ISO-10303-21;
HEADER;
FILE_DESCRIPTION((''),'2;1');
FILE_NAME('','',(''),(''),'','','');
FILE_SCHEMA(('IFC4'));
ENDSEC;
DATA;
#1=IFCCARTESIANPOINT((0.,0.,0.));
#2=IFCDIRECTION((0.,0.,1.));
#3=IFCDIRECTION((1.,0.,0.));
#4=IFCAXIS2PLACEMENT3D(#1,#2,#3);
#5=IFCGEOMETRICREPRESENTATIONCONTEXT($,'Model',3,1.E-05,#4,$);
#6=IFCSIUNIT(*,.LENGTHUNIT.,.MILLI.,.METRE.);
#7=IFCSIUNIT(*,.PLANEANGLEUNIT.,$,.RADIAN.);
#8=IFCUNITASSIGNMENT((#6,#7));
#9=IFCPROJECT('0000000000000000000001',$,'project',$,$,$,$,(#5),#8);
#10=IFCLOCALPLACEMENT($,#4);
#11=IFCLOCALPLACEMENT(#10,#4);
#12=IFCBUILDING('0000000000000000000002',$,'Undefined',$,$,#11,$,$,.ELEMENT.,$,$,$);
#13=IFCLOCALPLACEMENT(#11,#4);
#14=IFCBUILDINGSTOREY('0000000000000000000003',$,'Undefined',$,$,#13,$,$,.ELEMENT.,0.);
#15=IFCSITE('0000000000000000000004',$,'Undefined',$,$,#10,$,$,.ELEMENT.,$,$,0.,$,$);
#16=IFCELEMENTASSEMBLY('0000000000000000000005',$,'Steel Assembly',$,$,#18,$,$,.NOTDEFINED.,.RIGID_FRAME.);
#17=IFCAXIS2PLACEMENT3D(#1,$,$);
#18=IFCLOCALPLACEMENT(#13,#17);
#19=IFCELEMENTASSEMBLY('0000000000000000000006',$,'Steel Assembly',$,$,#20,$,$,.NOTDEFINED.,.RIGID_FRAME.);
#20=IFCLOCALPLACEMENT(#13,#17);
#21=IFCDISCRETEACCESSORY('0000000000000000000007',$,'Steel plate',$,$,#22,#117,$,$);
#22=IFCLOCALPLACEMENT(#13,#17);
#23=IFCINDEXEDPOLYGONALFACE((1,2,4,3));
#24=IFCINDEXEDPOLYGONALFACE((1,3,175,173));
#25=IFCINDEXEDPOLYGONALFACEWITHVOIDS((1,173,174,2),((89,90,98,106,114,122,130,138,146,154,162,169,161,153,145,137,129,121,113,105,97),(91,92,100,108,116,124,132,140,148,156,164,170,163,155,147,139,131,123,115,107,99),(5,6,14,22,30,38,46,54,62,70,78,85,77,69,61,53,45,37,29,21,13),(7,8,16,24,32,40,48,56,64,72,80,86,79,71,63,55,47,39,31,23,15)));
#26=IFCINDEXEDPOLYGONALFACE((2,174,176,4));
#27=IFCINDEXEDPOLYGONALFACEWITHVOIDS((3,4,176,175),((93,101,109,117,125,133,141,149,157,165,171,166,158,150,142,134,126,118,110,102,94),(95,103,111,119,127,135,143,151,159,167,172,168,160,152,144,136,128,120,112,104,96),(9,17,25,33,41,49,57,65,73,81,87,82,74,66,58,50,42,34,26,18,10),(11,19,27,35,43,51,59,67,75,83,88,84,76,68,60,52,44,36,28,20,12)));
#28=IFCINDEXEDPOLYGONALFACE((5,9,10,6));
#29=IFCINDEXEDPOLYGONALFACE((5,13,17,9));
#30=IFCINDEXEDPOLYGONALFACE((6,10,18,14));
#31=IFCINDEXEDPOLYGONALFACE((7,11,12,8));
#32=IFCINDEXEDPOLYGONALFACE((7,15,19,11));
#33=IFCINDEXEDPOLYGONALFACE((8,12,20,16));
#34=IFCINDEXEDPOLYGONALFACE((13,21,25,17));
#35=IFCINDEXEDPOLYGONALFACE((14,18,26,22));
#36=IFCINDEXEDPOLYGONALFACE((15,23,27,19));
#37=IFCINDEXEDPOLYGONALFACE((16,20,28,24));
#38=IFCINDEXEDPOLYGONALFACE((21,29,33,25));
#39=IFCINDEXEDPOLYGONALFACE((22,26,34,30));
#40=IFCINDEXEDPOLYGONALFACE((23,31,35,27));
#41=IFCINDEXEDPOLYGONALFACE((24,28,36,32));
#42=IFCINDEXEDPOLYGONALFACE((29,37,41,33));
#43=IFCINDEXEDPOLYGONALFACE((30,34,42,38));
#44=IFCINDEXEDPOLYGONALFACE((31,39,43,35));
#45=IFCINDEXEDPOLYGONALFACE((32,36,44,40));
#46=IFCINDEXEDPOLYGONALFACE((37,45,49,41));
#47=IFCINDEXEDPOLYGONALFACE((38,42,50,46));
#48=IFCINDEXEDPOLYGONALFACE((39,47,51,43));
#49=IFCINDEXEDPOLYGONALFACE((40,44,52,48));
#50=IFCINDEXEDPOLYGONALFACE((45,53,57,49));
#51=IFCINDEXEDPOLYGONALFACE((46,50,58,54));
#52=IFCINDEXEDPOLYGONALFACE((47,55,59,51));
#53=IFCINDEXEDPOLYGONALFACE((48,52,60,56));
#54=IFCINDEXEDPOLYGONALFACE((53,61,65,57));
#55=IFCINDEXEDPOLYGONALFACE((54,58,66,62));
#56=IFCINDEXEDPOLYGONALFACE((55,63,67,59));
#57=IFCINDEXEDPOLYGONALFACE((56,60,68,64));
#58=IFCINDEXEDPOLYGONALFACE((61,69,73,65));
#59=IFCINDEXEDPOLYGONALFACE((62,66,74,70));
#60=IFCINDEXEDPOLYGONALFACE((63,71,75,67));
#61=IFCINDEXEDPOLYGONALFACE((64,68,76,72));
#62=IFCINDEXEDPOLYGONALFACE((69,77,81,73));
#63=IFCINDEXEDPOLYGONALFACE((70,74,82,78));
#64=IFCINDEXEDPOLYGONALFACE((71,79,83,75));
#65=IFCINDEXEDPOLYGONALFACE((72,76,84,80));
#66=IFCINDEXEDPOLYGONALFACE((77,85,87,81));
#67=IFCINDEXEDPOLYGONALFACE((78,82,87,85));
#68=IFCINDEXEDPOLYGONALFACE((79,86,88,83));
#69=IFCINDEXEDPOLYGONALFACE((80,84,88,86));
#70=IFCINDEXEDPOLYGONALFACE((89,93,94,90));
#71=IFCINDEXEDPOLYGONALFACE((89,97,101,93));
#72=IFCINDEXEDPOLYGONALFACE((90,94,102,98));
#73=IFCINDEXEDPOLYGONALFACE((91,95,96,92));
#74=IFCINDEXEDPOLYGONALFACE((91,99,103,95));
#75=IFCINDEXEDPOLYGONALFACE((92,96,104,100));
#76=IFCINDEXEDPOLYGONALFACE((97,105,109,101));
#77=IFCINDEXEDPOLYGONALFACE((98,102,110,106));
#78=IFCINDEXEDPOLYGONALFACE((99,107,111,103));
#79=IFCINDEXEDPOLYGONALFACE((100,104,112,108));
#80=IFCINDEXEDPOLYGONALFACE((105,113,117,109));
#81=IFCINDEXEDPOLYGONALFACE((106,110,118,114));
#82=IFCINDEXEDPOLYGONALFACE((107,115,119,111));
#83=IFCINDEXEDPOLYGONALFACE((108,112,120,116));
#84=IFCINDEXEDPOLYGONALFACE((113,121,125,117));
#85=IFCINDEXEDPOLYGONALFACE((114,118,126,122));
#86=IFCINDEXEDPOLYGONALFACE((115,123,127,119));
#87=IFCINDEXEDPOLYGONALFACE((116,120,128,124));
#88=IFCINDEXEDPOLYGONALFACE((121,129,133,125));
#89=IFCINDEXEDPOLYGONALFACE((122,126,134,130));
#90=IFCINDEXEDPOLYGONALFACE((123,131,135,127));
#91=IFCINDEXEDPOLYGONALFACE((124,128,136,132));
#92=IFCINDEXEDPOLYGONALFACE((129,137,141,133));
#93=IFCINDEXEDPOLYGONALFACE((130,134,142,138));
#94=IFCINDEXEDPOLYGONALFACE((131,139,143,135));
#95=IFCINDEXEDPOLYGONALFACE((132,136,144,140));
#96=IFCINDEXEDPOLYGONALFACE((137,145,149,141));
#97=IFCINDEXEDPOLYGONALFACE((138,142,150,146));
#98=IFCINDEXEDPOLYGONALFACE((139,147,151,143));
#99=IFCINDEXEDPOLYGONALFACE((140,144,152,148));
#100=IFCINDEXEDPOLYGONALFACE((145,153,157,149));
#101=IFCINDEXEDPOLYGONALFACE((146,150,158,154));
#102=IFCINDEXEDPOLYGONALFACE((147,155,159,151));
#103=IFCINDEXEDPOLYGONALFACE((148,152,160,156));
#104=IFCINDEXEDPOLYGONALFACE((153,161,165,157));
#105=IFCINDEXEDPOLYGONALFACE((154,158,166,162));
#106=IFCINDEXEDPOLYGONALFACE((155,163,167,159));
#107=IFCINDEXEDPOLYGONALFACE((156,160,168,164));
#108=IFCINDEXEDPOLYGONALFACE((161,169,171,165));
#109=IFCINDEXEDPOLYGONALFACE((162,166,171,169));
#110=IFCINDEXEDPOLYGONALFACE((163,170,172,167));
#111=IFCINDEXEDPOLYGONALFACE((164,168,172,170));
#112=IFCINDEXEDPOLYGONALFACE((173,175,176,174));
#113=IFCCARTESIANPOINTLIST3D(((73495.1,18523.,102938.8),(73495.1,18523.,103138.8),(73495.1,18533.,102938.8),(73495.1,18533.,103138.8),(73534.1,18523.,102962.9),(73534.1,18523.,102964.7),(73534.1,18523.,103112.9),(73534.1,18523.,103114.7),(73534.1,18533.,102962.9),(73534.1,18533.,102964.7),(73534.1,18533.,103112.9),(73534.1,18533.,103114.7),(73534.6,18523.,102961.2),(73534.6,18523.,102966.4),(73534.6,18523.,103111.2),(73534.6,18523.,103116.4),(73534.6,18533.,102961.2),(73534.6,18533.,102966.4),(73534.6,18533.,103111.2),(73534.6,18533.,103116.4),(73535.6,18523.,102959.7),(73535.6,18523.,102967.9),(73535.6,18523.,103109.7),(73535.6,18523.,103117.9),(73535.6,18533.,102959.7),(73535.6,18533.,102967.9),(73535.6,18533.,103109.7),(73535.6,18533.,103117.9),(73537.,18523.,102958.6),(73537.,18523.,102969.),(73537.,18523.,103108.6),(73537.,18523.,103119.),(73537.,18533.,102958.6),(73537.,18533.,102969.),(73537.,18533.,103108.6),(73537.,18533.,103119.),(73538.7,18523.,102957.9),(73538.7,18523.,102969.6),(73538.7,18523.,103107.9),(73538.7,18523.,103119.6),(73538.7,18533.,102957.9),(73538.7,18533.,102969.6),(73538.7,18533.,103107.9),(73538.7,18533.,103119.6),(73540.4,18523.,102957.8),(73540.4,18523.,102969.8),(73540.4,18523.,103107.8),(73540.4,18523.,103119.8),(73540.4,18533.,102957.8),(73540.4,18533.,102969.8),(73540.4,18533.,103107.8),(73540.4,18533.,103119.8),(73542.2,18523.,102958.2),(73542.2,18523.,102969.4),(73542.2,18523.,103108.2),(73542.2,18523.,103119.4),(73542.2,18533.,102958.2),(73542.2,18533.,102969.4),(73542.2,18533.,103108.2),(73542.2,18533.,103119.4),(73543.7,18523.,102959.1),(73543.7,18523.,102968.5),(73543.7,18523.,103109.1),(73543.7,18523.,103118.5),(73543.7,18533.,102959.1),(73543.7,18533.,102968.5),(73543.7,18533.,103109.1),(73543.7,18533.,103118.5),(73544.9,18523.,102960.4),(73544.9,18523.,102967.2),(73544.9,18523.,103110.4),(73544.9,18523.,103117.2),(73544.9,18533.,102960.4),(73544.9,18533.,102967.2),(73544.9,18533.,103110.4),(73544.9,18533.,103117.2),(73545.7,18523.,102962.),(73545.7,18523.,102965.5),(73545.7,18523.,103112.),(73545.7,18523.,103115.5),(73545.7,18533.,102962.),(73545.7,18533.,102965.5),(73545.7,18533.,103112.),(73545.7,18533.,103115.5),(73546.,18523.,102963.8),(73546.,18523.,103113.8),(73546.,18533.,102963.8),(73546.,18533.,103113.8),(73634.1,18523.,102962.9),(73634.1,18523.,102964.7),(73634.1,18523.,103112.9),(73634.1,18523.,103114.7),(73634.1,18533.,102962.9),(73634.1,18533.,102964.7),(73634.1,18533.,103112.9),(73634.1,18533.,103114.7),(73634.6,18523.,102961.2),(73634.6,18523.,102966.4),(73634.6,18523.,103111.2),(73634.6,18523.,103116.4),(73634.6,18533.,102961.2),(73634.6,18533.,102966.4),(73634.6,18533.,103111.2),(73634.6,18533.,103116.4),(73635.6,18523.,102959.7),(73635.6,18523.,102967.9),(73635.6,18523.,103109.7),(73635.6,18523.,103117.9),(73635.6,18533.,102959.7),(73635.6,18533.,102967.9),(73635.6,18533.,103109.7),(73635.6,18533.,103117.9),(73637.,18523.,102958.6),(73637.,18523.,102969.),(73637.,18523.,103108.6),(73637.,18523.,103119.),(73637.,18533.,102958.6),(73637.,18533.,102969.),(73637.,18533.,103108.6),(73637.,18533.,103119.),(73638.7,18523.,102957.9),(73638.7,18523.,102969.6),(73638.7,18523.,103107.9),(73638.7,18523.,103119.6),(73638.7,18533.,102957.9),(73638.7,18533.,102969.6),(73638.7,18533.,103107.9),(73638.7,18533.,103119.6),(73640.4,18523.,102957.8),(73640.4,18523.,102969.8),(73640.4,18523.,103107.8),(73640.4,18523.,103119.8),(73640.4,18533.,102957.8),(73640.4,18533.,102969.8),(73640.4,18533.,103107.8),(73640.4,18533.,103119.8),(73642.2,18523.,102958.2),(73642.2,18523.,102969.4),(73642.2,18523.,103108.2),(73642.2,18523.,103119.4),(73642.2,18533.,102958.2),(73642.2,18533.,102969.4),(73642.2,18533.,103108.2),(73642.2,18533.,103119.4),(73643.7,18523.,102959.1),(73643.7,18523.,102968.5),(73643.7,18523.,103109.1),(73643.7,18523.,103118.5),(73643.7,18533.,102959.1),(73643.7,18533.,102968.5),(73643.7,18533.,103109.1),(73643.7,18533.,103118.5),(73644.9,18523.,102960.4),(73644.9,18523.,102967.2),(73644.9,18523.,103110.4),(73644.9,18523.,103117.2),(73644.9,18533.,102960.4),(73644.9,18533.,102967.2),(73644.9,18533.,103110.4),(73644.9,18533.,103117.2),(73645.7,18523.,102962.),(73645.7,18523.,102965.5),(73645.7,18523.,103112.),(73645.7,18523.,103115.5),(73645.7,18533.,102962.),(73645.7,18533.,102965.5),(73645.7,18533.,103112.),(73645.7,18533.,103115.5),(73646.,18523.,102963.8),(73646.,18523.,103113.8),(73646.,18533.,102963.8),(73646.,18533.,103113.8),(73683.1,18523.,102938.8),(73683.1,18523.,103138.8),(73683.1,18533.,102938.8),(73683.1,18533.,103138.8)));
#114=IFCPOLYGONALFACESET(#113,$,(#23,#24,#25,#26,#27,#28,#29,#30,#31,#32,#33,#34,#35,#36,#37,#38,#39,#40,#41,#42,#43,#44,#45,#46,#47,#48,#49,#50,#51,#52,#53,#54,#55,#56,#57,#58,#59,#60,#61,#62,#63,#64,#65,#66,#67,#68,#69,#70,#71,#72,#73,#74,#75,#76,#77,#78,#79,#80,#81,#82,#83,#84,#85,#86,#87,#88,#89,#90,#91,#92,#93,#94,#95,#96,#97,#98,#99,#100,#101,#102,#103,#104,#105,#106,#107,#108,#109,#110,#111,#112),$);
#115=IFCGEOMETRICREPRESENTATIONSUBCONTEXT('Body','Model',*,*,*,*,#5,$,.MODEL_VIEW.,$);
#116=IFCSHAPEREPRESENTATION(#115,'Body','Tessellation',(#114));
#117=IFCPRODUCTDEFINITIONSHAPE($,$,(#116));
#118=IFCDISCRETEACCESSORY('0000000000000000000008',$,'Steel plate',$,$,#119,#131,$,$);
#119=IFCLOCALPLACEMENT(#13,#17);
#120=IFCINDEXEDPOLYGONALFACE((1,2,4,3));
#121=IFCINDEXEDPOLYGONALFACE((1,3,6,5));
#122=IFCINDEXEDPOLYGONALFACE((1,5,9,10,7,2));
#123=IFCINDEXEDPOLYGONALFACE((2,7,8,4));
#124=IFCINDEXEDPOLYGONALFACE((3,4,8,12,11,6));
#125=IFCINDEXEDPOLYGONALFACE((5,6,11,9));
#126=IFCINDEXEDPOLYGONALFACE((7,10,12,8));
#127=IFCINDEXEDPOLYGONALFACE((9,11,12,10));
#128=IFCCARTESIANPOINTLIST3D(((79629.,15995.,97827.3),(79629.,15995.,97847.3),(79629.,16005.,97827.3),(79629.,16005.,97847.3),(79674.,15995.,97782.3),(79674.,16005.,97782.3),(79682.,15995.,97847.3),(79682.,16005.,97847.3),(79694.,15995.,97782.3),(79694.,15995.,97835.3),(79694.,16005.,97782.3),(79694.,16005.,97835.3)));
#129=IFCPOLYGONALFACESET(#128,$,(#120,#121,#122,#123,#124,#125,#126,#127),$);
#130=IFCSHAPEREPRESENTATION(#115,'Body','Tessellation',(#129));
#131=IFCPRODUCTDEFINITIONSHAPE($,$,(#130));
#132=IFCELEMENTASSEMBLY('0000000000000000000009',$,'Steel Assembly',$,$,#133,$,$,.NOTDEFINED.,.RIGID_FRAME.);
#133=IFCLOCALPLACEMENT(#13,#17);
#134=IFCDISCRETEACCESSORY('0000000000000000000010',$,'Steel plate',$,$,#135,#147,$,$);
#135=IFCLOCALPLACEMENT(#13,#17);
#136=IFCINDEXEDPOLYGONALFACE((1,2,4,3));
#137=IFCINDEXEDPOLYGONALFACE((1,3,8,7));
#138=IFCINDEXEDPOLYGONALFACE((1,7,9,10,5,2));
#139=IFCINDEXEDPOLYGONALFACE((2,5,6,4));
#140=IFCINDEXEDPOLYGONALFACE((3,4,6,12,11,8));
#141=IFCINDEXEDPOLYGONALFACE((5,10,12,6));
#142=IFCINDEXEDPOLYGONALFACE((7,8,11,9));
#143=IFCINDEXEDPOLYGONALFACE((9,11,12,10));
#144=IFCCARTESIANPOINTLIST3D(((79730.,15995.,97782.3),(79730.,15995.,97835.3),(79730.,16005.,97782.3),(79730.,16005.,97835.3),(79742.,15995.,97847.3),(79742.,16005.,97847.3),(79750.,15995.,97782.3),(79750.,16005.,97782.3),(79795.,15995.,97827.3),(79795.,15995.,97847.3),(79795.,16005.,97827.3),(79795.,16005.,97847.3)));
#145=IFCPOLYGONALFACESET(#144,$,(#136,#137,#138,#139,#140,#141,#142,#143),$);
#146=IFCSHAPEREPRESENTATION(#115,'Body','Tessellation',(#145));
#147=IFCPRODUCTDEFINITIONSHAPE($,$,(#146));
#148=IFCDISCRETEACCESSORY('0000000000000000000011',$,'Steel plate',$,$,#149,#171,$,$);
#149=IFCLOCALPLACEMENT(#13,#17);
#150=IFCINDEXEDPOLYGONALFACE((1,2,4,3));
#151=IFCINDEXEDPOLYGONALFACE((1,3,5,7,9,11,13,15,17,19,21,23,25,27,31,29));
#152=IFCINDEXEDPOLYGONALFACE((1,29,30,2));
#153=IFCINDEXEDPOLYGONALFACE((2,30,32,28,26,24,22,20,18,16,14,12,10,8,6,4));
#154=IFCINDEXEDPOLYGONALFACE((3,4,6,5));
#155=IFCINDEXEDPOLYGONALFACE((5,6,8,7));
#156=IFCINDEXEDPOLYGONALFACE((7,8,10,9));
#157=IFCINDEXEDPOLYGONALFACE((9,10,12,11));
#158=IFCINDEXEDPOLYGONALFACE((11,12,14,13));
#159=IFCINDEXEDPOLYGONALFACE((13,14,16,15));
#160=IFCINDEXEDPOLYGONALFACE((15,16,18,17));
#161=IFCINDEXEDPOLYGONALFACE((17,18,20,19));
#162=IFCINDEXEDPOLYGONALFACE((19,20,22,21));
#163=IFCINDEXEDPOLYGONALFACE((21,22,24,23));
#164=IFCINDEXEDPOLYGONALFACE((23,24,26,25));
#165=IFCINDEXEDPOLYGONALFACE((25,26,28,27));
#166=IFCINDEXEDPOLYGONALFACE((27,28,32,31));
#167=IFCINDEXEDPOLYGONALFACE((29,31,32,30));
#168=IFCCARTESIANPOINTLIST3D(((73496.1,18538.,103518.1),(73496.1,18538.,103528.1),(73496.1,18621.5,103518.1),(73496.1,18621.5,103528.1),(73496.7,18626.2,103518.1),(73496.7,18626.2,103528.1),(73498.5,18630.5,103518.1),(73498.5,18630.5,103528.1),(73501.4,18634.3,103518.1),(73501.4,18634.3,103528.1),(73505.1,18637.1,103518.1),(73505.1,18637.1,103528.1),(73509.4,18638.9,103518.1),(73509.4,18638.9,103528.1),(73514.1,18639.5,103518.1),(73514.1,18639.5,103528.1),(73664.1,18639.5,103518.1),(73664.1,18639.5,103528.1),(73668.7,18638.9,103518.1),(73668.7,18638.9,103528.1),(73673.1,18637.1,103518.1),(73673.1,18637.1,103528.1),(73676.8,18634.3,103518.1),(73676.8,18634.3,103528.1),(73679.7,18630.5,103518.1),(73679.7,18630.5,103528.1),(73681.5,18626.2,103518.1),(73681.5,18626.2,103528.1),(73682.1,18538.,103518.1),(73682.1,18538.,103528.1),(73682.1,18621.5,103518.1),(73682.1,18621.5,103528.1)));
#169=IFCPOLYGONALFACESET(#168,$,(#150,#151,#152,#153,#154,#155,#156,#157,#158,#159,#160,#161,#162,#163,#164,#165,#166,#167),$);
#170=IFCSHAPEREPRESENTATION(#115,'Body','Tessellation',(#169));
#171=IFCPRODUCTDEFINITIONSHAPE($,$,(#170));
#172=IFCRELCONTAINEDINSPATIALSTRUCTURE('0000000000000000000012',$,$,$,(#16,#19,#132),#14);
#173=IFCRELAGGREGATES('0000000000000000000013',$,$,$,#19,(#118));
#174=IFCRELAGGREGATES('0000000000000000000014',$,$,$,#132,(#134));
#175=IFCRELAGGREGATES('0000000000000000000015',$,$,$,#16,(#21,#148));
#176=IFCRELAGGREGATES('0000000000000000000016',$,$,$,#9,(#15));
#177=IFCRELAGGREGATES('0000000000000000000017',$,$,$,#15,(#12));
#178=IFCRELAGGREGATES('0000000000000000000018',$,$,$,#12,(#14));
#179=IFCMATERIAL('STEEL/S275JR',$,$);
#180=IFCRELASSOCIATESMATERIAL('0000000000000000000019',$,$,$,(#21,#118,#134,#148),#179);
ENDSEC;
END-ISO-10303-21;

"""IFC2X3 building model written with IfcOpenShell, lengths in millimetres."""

from ifc_helpers import new_model, si_unit, frame, frame_2d, origin_with_axes, origin_2d_with_axis, place, context, subcontext, project, spatial, polyline, circle_curve, parameter, trimmed, segment, composite_curve, circle, outline, extrude, source, transform, mapped, material, element, aggregate, save


model = new_model("IFC2X3")

# Units and contexts
model_context = context("Model", 3, precision=1e-05, world=origin_with_axes())
body_context = subcontext(model_context, "Body", "Model", "MODEL_VIEW")
ifc_project = project(units=[si_unit("LENGTHUNIT", "METRE", prefix="MILLI"), si_unit("PLANEANGLEUNIT", "RADIAN")], contexts=[model_context])

# Site, building, storey
site_placement = place(None, origin_with_axes())
site = spatial("IfcSite", under=ifc_project, at=site_placement, Name="Undefined", CompositionType="ELEMENT", RefElevation=0.0)
building_placement = place(site_placement, origin_with_axes())
building = spatial("IfcBuilding", under=site, at=building_placement, Name="Undefined", CompositionType="ELEMENT")
storey_placement = place(building_placement, origin_with_axes())
storey = spatial("IfcBuildingStorey", under=building, at=storey_placement, Name="Undefined", CompositionType="ELEMENT", Elevation=0.0)

# Element assembly
assembly_1_placement = place(storey_placement, origin_with_axes())
assembly_1 = element("IfcElementAssembly", 1, at=assembly_1_placement, inside=storey, Name="Steel Assembly", AssemblyPlace="NOTDEFINED", PredefinedType="RIGID_FRAME")

# Element assembly
assembly_2_placement = place(storey_placement, origin_with_axes())
assembly_2 = element("IfcElementAssembly", 2, at=assembly_2_placement, inside=storey, Name="Steel Assembly", AssemblyPlace="NOTDEFINED", PredefinedType="RIGID_FRAME")

# Discrete accessory, opening
ifc_material_1 = material(Name="STEEL/S275JR")
shared_shape_1 = source(origin_with_axes(), body_context, "Body", "SweptSolid", [
    extrude(circle(Radius=6.0, at=origin_2d_with_axis()), frame((0.0, -0.2, 0.0), z_axis=(0.0, 1.0, 0.0), x_axis=(1.0, 0.0, 0.0)), (0.0, 0.0, 1.0), 10.2),
])
discrete_accessory_1_placement = place(assembly_1_placement, frame((73683.1, 18528.0, 103138.8), z_axis=(0.0, -1.0, 0.0), x_axis=(-1.0, 0.0, 0.0)))
discrete_accessory_1 = element("IfcDiscreteAccessory", 3, at=discrete_accessory_1_placement, material=ifc_material_1, Name="Steel plate", context=body_context, shape_type="SweptSolid", body=[
    extrude(outline(polyline([(0.0, 0.0), (188.0, 0.0), (188.0, 200.0), (0.0, 200.0), (0.0, 0.0)])), frame((0.0, 0.0, -5.0), z_axis=(0.0, 0.0, 1.0), x_axis=(1.0, 0.0, 0.0)), (0.0, 0.0, 1.0), 10.0),
])
opening_1_placement = place(assembly_1_placement, frame((73540.0, 18523.1, 103038.8), z_axis=(0.0, 0.0, 1.0), x_axis=(1.0, 0.0, 0.0)))
element("IfcOpeningElement", 4, at=opening_1_placement, cuts=discrete_accessory_1, ObjectType="Opening", context=body_context, shape_type="MappedRepresentation", body=[
    mapped(shared_shape_1, transform((0.0, 0.0, -75.0))),
    mapped(shared_shape_1, transform((100.0, 0.0, -75.0))),
    mapped(shared_shape_1, transform((0.0, 0.0, 75.0))),
    mapped(shared_shape_1, transform((100.0, 0.0, 75.0))),
])

# Discrete accessory
discrete_accessory_2_placement = place(assembly_2_placement, frame((79629.0, 16000.0, 97847.3), z_axis=(0.0, 1.0, 0.0), x_axis=(1.0, 0.0, 0.0)))
discrete_accessory_2 = element("IfcDiscreteAccessory", 5, at=discrete_accessory_2_placement, material=ifc_material_1, Name="Steel plate", context=body_context, shape_type="SweptSolid", body=[
    extrude(outline(polyline([(0.0, 0.0), (53.0, 0.0), (65.0, 12.0), (65.0, 65.0), (45.0, 65.0), (0.0, 20.0), (0.0, 0.0)])), frame((0.0, 0.0, -5.0), z_axis=(0.0, 0.0, 1.0), x_axis=(1.0, 0.0, 0.0)), (0.0, 0.0, 1.0), 10.0),
])
aggregate(assembly_2, [discrete_accessory_2])

# Element assembly, discrete accessory
assembly_3_placement = place(storey_placement, origin_with_axes())
assembly_3 = element("IfcElementAssembly", 6, at=assembly_3_placement, inside=storey, Name="Steel Assembly", AssemblyPlace="NOTDEFINED", PredefinedType="RIGID_FRAME")
discrete_accessory_3_placement = place(assembly_3_placement, frame((79795.0, 16000.0, 97847.3), z_axis=(0.0, -1.0, 0.0), x_axis=(-1.0, 0.0, 0.0)))
discrete_accessory_3 = element("IfcDiscreteAccessory", 7, at=discrete_accessory_3_placement, material=ifc_material_1, Name="Steel plate", context=body_context, shape_type="SweptSolid", body=[
    extrude(outline(polyline([(0.0, 0.0), (53.0, 0.0), (65.0, 12.0), (65.0, 65.0), (45.0, 65.0), (0.0, 20.0), (0.0, 0.0)])), frame((0.0, 0.0, -5.0), z_axis=(0.0, 0.0, 1.0), x_axis=(1.0, 0.0, 0.0)), (0.0, 0.0, 1.0), 10.0),
])
aggregate(assembly_3, [discrete_accessory_3])

# Discrete accessory
discrete_accessory_4_placement = place(assembly_1_placement, frame((73496.1, 18538.0, 103523.1), z_axis=(0.0, 0.0, 1.0), x_axis=(1.0, 0.0, 0.0)))
discrete_accessory_4 = element("IfcDiscreteAccessory", 8, at=discrete_accessory_4_placement, material=ifc_material_1, Name="Steel plate", context=body_context, shape_type="SweptSolid", body=[
    extrude(outline(composite_curve([segment(polyline([(0.0, 0.0), (186.0, 0.0), (186.0, 83.5)]), True, "CONTINUOUS"), segment(trimmed(circle_curve(frame_2d((168.0, 83.5), x_axis=(1.0, 0.0)), 18.0), [parameter(0.0)], [parameter(1.570796)], True, "PARAMETER"), True, "CONTINUOUS"), segment(polyline([(168.0, 101.5), (18.0, 101.5)]), True, "CONTINUOUS"), segment(trimmed(circle_curve(frame_2d((18.0, 83.5), x_axis=(0.0, 1.0)), 18.0), [parameter(0.0)], [parameter(1.570796)], True, "PARAMETER"), True, "CONTINUOUS"), segment(polyline([(0.0, 83.5), (0.0, 0.0)]), True, "DISCONTINUOUS")], self_intersect=False)), frame((0.0, 0.0, -5.0), z_axis=(0.0, 0.0, 1.0), x_axis=(1.0, 0.0, 0.0)), (0.0, 0.0, 1.0), 10.0),
])

aggregate(assembly_1, [discrete_accessory_1, discrete_accessory_4])

save(model, "model.ifc")
